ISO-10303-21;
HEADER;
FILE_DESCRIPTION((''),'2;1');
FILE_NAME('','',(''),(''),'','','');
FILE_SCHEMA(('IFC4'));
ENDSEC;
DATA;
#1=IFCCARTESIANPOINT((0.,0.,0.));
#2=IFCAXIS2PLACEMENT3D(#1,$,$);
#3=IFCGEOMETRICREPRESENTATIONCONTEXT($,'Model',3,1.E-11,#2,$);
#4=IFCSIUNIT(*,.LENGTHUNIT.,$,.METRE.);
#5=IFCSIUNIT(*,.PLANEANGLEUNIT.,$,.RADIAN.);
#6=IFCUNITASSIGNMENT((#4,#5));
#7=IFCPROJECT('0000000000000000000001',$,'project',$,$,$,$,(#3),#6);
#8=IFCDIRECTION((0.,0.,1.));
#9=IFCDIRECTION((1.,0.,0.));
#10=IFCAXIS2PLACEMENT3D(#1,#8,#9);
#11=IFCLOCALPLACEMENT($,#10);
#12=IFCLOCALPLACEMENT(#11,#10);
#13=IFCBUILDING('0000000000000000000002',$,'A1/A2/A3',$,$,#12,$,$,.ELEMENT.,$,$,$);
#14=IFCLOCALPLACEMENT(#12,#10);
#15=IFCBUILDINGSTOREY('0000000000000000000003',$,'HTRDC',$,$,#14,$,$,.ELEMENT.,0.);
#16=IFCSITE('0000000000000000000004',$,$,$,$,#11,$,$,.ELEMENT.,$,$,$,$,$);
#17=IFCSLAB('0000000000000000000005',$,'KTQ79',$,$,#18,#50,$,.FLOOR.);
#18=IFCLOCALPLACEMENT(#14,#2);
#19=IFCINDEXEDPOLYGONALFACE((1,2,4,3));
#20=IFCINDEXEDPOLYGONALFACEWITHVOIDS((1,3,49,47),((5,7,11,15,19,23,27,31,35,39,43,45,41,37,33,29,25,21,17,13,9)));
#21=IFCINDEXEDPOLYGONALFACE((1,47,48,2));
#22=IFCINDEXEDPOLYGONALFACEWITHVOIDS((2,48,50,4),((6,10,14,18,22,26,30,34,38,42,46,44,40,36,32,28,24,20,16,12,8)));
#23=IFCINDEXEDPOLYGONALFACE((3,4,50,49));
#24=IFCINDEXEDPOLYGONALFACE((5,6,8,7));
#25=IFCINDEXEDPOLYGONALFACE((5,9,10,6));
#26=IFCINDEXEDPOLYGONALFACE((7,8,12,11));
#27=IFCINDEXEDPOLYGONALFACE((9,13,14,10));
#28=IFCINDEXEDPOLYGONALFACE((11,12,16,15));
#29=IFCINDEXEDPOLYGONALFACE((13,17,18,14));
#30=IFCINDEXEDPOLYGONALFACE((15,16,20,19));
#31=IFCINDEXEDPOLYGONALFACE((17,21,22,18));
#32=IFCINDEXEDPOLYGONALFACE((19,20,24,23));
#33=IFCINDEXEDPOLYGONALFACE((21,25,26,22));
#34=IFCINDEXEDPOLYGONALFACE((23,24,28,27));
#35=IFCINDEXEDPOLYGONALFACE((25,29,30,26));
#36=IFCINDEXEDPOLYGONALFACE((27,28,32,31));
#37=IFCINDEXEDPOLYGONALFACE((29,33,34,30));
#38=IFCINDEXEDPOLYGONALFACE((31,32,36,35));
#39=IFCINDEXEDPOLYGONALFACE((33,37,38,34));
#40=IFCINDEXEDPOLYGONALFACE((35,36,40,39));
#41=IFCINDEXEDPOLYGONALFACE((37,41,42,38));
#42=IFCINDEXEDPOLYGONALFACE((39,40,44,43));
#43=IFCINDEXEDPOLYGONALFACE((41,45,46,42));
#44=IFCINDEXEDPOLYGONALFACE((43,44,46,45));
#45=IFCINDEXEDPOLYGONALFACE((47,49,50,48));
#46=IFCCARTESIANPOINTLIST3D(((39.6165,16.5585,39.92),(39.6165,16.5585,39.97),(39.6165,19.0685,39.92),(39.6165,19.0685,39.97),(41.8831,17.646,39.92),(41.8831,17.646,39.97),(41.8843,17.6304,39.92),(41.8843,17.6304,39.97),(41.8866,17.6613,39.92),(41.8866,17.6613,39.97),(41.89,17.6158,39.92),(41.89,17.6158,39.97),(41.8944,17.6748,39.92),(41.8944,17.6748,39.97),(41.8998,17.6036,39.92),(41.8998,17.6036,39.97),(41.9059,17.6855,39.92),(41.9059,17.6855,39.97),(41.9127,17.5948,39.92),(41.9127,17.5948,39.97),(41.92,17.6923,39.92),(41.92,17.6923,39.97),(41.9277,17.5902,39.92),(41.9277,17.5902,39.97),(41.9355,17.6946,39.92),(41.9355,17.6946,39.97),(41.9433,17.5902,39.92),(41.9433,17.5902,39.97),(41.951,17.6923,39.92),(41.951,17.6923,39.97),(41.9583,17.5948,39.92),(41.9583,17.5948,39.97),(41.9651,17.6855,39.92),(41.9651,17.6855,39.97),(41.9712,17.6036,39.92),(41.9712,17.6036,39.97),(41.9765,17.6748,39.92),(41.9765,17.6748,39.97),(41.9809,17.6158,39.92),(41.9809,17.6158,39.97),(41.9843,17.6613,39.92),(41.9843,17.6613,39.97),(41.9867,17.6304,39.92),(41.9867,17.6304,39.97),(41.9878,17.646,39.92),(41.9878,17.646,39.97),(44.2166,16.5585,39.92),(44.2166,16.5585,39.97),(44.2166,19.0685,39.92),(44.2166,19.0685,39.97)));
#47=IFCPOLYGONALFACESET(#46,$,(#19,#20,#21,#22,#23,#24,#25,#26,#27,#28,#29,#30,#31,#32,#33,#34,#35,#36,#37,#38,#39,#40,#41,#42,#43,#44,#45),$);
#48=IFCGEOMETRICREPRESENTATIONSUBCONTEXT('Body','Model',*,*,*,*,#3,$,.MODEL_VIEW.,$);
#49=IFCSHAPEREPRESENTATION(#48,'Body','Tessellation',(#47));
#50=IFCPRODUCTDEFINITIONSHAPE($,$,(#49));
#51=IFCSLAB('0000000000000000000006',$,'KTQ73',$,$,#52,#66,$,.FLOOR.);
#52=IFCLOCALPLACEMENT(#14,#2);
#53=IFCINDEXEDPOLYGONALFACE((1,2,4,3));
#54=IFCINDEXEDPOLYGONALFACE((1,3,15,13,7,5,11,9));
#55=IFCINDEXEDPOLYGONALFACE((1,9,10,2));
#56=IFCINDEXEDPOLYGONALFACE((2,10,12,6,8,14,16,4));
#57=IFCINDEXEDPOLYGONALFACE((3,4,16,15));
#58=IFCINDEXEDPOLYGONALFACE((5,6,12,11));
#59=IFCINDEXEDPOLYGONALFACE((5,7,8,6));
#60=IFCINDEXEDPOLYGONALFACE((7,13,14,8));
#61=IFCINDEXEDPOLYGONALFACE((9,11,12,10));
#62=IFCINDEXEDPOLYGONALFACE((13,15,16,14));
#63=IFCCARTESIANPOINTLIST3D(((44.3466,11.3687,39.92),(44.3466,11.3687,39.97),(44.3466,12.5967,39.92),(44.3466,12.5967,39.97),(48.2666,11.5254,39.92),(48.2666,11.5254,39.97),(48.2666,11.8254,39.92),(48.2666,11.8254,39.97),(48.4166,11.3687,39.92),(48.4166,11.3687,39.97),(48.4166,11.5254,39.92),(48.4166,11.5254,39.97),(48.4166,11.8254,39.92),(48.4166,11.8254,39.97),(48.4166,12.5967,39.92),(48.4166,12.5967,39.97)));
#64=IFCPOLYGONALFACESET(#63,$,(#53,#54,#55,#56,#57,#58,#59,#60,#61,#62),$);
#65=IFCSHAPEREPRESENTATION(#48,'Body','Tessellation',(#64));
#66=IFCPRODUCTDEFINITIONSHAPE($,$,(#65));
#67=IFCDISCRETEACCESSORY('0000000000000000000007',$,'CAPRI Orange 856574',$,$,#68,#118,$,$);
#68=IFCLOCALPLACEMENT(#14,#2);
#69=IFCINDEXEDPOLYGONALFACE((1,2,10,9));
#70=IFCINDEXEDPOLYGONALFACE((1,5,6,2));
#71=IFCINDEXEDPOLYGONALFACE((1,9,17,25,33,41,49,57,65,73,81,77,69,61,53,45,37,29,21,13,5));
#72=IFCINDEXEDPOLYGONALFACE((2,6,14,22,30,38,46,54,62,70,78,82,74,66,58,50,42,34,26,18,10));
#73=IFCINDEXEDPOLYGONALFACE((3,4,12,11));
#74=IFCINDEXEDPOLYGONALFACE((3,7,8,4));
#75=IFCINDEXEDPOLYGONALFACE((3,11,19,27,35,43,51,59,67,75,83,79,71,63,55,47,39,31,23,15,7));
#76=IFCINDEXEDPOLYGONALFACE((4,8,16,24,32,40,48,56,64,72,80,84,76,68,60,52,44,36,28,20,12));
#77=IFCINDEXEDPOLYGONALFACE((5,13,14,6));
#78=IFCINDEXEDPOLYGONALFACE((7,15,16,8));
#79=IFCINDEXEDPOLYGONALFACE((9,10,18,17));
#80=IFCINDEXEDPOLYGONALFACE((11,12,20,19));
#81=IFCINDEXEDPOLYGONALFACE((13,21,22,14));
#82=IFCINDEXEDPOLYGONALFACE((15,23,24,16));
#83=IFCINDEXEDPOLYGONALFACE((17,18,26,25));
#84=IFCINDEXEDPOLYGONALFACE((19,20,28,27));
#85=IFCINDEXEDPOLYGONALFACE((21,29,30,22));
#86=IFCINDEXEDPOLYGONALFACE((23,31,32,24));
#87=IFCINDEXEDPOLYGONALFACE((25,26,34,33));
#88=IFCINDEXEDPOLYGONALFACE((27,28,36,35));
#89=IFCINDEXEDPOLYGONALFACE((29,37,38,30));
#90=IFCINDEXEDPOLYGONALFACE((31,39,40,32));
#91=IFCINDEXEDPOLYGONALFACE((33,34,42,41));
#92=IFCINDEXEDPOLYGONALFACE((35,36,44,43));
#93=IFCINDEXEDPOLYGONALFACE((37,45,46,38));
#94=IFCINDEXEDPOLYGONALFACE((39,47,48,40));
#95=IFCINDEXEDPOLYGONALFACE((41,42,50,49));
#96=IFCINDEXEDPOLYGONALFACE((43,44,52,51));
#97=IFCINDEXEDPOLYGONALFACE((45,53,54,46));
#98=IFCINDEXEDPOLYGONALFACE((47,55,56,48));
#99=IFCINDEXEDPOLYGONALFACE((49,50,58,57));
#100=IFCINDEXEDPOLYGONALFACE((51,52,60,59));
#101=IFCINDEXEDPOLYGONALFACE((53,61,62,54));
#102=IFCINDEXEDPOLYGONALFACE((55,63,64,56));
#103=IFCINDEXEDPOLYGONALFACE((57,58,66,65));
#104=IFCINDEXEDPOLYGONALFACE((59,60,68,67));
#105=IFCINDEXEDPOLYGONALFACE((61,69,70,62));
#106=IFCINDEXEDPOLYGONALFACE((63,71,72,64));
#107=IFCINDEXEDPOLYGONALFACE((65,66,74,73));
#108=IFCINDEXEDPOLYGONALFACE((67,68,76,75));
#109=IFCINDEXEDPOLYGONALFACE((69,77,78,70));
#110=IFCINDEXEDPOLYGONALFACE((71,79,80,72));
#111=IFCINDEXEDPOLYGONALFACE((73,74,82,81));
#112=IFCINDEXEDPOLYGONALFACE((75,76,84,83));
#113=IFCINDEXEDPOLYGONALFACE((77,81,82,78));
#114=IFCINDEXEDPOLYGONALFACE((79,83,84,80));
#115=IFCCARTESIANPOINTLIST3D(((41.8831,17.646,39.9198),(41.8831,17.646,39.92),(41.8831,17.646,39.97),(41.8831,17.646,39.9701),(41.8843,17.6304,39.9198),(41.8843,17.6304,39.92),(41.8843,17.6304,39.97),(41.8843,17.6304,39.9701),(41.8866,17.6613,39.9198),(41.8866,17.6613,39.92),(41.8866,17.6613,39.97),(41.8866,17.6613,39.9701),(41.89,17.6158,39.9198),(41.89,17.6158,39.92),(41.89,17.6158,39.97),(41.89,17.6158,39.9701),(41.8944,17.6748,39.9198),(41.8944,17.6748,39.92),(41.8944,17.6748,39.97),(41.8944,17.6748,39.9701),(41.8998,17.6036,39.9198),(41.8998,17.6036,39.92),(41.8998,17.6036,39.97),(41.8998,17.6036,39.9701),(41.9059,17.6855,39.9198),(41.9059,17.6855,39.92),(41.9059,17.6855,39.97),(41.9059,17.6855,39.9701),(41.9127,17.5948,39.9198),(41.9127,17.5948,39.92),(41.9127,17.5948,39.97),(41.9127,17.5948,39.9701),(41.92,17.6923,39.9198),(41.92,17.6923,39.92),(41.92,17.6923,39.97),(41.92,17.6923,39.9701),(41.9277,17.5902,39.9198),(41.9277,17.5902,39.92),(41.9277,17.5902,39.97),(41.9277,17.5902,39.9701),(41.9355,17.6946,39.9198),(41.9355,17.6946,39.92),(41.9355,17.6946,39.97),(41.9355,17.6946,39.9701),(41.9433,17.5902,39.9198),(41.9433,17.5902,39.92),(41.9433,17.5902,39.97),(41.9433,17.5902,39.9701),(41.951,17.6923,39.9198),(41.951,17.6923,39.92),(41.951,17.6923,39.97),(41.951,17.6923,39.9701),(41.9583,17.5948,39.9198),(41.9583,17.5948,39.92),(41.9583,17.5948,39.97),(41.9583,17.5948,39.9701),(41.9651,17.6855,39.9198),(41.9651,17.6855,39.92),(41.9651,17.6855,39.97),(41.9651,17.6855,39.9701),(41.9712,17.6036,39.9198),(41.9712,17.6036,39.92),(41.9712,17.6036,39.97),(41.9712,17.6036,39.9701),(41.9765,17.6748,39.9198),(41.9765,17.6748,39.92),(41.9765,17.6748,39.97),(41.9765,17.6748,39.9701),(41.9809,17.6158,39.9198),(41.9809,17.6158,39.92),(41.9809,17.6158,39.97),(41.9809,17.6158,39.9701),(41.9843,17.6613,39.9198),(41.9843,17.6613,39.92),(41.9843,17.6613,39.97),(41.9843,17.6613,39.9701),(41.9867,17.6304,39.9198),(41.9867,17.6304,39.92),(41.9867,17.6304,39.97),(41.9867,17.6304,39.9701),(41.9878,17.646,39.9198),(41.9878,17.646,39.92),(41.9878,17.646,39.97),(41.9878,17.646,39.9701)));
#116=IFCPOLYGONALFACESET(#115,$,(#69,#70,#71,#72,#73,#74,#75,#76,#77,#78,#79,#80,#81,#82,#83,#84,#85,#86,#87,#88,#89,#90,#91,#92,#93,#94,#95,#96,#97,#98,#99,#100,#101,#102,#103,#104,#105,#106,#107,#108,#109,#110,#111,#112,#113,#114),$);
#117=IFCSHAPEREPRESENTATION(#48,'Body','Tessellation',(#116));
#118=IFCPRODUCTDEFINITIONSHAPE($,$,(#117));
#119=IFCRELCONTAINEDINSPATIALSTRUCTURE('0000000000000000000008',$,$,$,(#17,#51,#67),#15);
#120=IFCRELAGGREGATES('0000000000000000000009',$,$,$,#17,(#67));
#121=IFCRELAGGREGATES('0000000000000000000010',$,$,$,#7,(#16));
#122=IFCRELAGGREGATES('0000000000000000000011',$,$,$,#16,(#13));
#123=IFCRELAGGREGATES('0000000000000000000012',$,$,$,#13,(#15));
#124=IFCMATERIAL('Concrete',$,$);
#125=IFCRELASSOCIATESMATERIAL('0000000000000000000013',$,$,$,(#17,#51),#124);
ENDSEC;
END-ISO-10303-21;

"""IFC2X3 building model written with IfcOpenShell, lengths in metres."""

from ifc_helpers import new_model, si_unit, frame, frame_2d, origin, origin_with_axes, origin_2d_with_axis, place, context, subcontext, project, spatial, polyline, circle, outline, extrude, material, element, aggregate, save


model = new_model("IFC2X3")

# Units and contexts
model_context = context("Model", 3, precision=1e-11, world=origin())
body_context = subcontext(model_context, "Body", "Model", "MODEL_VIEW")
ifc_project = project(units=[si_unit("LENGTHUNIT", "METRE"), si_unit("PLANEANGLEUNIT", "RADIAN")], contexts=[model_context])

# Site, building, storey
site_placement = place(None, origin_with_axes())
site = spatial("IfcSite", under=ifc_project, at=site_placement, CompositionType="ELEMENT")
building_placement = place(site_placement, origin_with_axes())
building = spatial("IfcBuilding", under=site, at=building_placement, Name="A1/A2/A3", CompositionType="ELEMENT")
storey_placement = place(building_placement, origin_with_axes())
storey = spatial("IfcBuildingStorey", under=building, at=storey_placement, Name="HTRDC", CompositionType="ELEMENT", Elevation=0.0)

# Slabs, openings
ifc_material = material(Name="Concrete")
slab_1_placement = place(storey_placement, frame((39.6165, 16.5585, 39.92), z_axis=(0.0, 0.0, 1.0), x_axis=(1.0, 0.0, 0.0)))
slab_1 = element("IfcSlab", 1, at=slab_1_placement, inside=storey, material=ifc_material, Name="KTQ79", PredefinedType="FLOOR", context=body_context, shape_type="SweptSolid", body=[
    extrude(outline(polyline([(0.0, 0.0), (0.0, -4.6001), (2.51, -4.6001), (2.51, 0.0), (0.0, 0.0)])), frame((0.0, 0.0, 0.0), z_axis=(0.0, 0.0, 1.0), x_axis=(0.0, 1.0, 0.0)), (0.0, 0.0, 1.0), 0.05),
])
opening_1_placement = place(slab_1_placement, frame((2.319, 1.0836, 0.0), z_axis=(0.0, 0.0, 1.0), x_axis=(1.0, 0.0, 0.0)))
element("IfcOpeningElement", 2, at=opening_1_placement, cuts=slab_1, ObjectType="Opening", context=body_context, shape_type="SweptSolid", body=[
    extrude(circle(Radius=0.0525, at=origin_2d_with_axis()), frame((0.0, 0.0, 0.0), z_axis=(0.0, 0.0, 1.0), x_axis=(0.0, 1.0, 0.0)), (0.0, 0.0, 1.0), 0.05),
])
slab_2_placement = place(storey_placement, frame((44.3466, 11.3687, 39.92), z_axis=(0.0, 0.0, 1.0), x_axis=(1.0, 0.0, 0.0)))
slab_2 = element("IfcSlab", 3, at=slab_2_placement, inside=storey, material=ifc_material, Name="KTQ73", PredefinedType="FLOOR", context=body_context, shape_type="SweptSolid", body=[
    extrude(outline(polyline([(0.0, 0.0), (0.0, -4.07), (1.228, -4.07), (1.228, 0.0), (0.0, 0.0)])), frame((0.0, 0.0, 0.0), z_axis=(0.0, 0.0, 1.0), x_axis=(0.0, 1.0, 0.0)), (0.0, 0.0, 1.0), 0.05),
])
opening_2_placement = place(slab_2_placement, origin_with_axes())
element("IfcOpeningElement", 4, at=opening_2_placement, cuts=slab_2, ObjectType="Opening", context=body_context, shape_type="SweptSolid", body=[
    extrude(outline(polyline([(0.1566, -3.92), (0.1566, -4.07), (0.4566, -4.07), (0.4566, -3.92), (0.1566, -3.92)])), frame((0.0, 0.0, 0.0), z_axis=(0.0, 0.0, 1.0), x_axis=(0.0, 1.0, 0.0)), (0.0, 0.0, 1.0), 0.05),
])

# Discrete accessory
discrete_accessory_1_placement = place(storey_placement, frame((39.6165, 16.5585, 39.9198), z_axis=(0.0, 0.0, 1.0), x_axis=(1.0, 0.0, 0.0)))
discrete_accessory_1 = element("IfcDiscreteAccessory", 5, at=discrete_accessory_1_placement, inside=storey, Name="CAPRI Orange 856574", context=body_context, shape_type="SweptSolid", body=[
    extrude(circle(Radius=0.0525, at=frame_2d((1.0836, -2.319), x_axis=(1.0, 0.0))), frame((0.0, 0.0, 0.0), z_axis=(0.0, 0.0, 1.0), x_axis=(0.0, 1.0, 0.0)), (0.0, 0.0, 1.0), 0.0503),
])
aggregate(slab_1, [discrete_accessory_1])

save(model, "model.ifc")
